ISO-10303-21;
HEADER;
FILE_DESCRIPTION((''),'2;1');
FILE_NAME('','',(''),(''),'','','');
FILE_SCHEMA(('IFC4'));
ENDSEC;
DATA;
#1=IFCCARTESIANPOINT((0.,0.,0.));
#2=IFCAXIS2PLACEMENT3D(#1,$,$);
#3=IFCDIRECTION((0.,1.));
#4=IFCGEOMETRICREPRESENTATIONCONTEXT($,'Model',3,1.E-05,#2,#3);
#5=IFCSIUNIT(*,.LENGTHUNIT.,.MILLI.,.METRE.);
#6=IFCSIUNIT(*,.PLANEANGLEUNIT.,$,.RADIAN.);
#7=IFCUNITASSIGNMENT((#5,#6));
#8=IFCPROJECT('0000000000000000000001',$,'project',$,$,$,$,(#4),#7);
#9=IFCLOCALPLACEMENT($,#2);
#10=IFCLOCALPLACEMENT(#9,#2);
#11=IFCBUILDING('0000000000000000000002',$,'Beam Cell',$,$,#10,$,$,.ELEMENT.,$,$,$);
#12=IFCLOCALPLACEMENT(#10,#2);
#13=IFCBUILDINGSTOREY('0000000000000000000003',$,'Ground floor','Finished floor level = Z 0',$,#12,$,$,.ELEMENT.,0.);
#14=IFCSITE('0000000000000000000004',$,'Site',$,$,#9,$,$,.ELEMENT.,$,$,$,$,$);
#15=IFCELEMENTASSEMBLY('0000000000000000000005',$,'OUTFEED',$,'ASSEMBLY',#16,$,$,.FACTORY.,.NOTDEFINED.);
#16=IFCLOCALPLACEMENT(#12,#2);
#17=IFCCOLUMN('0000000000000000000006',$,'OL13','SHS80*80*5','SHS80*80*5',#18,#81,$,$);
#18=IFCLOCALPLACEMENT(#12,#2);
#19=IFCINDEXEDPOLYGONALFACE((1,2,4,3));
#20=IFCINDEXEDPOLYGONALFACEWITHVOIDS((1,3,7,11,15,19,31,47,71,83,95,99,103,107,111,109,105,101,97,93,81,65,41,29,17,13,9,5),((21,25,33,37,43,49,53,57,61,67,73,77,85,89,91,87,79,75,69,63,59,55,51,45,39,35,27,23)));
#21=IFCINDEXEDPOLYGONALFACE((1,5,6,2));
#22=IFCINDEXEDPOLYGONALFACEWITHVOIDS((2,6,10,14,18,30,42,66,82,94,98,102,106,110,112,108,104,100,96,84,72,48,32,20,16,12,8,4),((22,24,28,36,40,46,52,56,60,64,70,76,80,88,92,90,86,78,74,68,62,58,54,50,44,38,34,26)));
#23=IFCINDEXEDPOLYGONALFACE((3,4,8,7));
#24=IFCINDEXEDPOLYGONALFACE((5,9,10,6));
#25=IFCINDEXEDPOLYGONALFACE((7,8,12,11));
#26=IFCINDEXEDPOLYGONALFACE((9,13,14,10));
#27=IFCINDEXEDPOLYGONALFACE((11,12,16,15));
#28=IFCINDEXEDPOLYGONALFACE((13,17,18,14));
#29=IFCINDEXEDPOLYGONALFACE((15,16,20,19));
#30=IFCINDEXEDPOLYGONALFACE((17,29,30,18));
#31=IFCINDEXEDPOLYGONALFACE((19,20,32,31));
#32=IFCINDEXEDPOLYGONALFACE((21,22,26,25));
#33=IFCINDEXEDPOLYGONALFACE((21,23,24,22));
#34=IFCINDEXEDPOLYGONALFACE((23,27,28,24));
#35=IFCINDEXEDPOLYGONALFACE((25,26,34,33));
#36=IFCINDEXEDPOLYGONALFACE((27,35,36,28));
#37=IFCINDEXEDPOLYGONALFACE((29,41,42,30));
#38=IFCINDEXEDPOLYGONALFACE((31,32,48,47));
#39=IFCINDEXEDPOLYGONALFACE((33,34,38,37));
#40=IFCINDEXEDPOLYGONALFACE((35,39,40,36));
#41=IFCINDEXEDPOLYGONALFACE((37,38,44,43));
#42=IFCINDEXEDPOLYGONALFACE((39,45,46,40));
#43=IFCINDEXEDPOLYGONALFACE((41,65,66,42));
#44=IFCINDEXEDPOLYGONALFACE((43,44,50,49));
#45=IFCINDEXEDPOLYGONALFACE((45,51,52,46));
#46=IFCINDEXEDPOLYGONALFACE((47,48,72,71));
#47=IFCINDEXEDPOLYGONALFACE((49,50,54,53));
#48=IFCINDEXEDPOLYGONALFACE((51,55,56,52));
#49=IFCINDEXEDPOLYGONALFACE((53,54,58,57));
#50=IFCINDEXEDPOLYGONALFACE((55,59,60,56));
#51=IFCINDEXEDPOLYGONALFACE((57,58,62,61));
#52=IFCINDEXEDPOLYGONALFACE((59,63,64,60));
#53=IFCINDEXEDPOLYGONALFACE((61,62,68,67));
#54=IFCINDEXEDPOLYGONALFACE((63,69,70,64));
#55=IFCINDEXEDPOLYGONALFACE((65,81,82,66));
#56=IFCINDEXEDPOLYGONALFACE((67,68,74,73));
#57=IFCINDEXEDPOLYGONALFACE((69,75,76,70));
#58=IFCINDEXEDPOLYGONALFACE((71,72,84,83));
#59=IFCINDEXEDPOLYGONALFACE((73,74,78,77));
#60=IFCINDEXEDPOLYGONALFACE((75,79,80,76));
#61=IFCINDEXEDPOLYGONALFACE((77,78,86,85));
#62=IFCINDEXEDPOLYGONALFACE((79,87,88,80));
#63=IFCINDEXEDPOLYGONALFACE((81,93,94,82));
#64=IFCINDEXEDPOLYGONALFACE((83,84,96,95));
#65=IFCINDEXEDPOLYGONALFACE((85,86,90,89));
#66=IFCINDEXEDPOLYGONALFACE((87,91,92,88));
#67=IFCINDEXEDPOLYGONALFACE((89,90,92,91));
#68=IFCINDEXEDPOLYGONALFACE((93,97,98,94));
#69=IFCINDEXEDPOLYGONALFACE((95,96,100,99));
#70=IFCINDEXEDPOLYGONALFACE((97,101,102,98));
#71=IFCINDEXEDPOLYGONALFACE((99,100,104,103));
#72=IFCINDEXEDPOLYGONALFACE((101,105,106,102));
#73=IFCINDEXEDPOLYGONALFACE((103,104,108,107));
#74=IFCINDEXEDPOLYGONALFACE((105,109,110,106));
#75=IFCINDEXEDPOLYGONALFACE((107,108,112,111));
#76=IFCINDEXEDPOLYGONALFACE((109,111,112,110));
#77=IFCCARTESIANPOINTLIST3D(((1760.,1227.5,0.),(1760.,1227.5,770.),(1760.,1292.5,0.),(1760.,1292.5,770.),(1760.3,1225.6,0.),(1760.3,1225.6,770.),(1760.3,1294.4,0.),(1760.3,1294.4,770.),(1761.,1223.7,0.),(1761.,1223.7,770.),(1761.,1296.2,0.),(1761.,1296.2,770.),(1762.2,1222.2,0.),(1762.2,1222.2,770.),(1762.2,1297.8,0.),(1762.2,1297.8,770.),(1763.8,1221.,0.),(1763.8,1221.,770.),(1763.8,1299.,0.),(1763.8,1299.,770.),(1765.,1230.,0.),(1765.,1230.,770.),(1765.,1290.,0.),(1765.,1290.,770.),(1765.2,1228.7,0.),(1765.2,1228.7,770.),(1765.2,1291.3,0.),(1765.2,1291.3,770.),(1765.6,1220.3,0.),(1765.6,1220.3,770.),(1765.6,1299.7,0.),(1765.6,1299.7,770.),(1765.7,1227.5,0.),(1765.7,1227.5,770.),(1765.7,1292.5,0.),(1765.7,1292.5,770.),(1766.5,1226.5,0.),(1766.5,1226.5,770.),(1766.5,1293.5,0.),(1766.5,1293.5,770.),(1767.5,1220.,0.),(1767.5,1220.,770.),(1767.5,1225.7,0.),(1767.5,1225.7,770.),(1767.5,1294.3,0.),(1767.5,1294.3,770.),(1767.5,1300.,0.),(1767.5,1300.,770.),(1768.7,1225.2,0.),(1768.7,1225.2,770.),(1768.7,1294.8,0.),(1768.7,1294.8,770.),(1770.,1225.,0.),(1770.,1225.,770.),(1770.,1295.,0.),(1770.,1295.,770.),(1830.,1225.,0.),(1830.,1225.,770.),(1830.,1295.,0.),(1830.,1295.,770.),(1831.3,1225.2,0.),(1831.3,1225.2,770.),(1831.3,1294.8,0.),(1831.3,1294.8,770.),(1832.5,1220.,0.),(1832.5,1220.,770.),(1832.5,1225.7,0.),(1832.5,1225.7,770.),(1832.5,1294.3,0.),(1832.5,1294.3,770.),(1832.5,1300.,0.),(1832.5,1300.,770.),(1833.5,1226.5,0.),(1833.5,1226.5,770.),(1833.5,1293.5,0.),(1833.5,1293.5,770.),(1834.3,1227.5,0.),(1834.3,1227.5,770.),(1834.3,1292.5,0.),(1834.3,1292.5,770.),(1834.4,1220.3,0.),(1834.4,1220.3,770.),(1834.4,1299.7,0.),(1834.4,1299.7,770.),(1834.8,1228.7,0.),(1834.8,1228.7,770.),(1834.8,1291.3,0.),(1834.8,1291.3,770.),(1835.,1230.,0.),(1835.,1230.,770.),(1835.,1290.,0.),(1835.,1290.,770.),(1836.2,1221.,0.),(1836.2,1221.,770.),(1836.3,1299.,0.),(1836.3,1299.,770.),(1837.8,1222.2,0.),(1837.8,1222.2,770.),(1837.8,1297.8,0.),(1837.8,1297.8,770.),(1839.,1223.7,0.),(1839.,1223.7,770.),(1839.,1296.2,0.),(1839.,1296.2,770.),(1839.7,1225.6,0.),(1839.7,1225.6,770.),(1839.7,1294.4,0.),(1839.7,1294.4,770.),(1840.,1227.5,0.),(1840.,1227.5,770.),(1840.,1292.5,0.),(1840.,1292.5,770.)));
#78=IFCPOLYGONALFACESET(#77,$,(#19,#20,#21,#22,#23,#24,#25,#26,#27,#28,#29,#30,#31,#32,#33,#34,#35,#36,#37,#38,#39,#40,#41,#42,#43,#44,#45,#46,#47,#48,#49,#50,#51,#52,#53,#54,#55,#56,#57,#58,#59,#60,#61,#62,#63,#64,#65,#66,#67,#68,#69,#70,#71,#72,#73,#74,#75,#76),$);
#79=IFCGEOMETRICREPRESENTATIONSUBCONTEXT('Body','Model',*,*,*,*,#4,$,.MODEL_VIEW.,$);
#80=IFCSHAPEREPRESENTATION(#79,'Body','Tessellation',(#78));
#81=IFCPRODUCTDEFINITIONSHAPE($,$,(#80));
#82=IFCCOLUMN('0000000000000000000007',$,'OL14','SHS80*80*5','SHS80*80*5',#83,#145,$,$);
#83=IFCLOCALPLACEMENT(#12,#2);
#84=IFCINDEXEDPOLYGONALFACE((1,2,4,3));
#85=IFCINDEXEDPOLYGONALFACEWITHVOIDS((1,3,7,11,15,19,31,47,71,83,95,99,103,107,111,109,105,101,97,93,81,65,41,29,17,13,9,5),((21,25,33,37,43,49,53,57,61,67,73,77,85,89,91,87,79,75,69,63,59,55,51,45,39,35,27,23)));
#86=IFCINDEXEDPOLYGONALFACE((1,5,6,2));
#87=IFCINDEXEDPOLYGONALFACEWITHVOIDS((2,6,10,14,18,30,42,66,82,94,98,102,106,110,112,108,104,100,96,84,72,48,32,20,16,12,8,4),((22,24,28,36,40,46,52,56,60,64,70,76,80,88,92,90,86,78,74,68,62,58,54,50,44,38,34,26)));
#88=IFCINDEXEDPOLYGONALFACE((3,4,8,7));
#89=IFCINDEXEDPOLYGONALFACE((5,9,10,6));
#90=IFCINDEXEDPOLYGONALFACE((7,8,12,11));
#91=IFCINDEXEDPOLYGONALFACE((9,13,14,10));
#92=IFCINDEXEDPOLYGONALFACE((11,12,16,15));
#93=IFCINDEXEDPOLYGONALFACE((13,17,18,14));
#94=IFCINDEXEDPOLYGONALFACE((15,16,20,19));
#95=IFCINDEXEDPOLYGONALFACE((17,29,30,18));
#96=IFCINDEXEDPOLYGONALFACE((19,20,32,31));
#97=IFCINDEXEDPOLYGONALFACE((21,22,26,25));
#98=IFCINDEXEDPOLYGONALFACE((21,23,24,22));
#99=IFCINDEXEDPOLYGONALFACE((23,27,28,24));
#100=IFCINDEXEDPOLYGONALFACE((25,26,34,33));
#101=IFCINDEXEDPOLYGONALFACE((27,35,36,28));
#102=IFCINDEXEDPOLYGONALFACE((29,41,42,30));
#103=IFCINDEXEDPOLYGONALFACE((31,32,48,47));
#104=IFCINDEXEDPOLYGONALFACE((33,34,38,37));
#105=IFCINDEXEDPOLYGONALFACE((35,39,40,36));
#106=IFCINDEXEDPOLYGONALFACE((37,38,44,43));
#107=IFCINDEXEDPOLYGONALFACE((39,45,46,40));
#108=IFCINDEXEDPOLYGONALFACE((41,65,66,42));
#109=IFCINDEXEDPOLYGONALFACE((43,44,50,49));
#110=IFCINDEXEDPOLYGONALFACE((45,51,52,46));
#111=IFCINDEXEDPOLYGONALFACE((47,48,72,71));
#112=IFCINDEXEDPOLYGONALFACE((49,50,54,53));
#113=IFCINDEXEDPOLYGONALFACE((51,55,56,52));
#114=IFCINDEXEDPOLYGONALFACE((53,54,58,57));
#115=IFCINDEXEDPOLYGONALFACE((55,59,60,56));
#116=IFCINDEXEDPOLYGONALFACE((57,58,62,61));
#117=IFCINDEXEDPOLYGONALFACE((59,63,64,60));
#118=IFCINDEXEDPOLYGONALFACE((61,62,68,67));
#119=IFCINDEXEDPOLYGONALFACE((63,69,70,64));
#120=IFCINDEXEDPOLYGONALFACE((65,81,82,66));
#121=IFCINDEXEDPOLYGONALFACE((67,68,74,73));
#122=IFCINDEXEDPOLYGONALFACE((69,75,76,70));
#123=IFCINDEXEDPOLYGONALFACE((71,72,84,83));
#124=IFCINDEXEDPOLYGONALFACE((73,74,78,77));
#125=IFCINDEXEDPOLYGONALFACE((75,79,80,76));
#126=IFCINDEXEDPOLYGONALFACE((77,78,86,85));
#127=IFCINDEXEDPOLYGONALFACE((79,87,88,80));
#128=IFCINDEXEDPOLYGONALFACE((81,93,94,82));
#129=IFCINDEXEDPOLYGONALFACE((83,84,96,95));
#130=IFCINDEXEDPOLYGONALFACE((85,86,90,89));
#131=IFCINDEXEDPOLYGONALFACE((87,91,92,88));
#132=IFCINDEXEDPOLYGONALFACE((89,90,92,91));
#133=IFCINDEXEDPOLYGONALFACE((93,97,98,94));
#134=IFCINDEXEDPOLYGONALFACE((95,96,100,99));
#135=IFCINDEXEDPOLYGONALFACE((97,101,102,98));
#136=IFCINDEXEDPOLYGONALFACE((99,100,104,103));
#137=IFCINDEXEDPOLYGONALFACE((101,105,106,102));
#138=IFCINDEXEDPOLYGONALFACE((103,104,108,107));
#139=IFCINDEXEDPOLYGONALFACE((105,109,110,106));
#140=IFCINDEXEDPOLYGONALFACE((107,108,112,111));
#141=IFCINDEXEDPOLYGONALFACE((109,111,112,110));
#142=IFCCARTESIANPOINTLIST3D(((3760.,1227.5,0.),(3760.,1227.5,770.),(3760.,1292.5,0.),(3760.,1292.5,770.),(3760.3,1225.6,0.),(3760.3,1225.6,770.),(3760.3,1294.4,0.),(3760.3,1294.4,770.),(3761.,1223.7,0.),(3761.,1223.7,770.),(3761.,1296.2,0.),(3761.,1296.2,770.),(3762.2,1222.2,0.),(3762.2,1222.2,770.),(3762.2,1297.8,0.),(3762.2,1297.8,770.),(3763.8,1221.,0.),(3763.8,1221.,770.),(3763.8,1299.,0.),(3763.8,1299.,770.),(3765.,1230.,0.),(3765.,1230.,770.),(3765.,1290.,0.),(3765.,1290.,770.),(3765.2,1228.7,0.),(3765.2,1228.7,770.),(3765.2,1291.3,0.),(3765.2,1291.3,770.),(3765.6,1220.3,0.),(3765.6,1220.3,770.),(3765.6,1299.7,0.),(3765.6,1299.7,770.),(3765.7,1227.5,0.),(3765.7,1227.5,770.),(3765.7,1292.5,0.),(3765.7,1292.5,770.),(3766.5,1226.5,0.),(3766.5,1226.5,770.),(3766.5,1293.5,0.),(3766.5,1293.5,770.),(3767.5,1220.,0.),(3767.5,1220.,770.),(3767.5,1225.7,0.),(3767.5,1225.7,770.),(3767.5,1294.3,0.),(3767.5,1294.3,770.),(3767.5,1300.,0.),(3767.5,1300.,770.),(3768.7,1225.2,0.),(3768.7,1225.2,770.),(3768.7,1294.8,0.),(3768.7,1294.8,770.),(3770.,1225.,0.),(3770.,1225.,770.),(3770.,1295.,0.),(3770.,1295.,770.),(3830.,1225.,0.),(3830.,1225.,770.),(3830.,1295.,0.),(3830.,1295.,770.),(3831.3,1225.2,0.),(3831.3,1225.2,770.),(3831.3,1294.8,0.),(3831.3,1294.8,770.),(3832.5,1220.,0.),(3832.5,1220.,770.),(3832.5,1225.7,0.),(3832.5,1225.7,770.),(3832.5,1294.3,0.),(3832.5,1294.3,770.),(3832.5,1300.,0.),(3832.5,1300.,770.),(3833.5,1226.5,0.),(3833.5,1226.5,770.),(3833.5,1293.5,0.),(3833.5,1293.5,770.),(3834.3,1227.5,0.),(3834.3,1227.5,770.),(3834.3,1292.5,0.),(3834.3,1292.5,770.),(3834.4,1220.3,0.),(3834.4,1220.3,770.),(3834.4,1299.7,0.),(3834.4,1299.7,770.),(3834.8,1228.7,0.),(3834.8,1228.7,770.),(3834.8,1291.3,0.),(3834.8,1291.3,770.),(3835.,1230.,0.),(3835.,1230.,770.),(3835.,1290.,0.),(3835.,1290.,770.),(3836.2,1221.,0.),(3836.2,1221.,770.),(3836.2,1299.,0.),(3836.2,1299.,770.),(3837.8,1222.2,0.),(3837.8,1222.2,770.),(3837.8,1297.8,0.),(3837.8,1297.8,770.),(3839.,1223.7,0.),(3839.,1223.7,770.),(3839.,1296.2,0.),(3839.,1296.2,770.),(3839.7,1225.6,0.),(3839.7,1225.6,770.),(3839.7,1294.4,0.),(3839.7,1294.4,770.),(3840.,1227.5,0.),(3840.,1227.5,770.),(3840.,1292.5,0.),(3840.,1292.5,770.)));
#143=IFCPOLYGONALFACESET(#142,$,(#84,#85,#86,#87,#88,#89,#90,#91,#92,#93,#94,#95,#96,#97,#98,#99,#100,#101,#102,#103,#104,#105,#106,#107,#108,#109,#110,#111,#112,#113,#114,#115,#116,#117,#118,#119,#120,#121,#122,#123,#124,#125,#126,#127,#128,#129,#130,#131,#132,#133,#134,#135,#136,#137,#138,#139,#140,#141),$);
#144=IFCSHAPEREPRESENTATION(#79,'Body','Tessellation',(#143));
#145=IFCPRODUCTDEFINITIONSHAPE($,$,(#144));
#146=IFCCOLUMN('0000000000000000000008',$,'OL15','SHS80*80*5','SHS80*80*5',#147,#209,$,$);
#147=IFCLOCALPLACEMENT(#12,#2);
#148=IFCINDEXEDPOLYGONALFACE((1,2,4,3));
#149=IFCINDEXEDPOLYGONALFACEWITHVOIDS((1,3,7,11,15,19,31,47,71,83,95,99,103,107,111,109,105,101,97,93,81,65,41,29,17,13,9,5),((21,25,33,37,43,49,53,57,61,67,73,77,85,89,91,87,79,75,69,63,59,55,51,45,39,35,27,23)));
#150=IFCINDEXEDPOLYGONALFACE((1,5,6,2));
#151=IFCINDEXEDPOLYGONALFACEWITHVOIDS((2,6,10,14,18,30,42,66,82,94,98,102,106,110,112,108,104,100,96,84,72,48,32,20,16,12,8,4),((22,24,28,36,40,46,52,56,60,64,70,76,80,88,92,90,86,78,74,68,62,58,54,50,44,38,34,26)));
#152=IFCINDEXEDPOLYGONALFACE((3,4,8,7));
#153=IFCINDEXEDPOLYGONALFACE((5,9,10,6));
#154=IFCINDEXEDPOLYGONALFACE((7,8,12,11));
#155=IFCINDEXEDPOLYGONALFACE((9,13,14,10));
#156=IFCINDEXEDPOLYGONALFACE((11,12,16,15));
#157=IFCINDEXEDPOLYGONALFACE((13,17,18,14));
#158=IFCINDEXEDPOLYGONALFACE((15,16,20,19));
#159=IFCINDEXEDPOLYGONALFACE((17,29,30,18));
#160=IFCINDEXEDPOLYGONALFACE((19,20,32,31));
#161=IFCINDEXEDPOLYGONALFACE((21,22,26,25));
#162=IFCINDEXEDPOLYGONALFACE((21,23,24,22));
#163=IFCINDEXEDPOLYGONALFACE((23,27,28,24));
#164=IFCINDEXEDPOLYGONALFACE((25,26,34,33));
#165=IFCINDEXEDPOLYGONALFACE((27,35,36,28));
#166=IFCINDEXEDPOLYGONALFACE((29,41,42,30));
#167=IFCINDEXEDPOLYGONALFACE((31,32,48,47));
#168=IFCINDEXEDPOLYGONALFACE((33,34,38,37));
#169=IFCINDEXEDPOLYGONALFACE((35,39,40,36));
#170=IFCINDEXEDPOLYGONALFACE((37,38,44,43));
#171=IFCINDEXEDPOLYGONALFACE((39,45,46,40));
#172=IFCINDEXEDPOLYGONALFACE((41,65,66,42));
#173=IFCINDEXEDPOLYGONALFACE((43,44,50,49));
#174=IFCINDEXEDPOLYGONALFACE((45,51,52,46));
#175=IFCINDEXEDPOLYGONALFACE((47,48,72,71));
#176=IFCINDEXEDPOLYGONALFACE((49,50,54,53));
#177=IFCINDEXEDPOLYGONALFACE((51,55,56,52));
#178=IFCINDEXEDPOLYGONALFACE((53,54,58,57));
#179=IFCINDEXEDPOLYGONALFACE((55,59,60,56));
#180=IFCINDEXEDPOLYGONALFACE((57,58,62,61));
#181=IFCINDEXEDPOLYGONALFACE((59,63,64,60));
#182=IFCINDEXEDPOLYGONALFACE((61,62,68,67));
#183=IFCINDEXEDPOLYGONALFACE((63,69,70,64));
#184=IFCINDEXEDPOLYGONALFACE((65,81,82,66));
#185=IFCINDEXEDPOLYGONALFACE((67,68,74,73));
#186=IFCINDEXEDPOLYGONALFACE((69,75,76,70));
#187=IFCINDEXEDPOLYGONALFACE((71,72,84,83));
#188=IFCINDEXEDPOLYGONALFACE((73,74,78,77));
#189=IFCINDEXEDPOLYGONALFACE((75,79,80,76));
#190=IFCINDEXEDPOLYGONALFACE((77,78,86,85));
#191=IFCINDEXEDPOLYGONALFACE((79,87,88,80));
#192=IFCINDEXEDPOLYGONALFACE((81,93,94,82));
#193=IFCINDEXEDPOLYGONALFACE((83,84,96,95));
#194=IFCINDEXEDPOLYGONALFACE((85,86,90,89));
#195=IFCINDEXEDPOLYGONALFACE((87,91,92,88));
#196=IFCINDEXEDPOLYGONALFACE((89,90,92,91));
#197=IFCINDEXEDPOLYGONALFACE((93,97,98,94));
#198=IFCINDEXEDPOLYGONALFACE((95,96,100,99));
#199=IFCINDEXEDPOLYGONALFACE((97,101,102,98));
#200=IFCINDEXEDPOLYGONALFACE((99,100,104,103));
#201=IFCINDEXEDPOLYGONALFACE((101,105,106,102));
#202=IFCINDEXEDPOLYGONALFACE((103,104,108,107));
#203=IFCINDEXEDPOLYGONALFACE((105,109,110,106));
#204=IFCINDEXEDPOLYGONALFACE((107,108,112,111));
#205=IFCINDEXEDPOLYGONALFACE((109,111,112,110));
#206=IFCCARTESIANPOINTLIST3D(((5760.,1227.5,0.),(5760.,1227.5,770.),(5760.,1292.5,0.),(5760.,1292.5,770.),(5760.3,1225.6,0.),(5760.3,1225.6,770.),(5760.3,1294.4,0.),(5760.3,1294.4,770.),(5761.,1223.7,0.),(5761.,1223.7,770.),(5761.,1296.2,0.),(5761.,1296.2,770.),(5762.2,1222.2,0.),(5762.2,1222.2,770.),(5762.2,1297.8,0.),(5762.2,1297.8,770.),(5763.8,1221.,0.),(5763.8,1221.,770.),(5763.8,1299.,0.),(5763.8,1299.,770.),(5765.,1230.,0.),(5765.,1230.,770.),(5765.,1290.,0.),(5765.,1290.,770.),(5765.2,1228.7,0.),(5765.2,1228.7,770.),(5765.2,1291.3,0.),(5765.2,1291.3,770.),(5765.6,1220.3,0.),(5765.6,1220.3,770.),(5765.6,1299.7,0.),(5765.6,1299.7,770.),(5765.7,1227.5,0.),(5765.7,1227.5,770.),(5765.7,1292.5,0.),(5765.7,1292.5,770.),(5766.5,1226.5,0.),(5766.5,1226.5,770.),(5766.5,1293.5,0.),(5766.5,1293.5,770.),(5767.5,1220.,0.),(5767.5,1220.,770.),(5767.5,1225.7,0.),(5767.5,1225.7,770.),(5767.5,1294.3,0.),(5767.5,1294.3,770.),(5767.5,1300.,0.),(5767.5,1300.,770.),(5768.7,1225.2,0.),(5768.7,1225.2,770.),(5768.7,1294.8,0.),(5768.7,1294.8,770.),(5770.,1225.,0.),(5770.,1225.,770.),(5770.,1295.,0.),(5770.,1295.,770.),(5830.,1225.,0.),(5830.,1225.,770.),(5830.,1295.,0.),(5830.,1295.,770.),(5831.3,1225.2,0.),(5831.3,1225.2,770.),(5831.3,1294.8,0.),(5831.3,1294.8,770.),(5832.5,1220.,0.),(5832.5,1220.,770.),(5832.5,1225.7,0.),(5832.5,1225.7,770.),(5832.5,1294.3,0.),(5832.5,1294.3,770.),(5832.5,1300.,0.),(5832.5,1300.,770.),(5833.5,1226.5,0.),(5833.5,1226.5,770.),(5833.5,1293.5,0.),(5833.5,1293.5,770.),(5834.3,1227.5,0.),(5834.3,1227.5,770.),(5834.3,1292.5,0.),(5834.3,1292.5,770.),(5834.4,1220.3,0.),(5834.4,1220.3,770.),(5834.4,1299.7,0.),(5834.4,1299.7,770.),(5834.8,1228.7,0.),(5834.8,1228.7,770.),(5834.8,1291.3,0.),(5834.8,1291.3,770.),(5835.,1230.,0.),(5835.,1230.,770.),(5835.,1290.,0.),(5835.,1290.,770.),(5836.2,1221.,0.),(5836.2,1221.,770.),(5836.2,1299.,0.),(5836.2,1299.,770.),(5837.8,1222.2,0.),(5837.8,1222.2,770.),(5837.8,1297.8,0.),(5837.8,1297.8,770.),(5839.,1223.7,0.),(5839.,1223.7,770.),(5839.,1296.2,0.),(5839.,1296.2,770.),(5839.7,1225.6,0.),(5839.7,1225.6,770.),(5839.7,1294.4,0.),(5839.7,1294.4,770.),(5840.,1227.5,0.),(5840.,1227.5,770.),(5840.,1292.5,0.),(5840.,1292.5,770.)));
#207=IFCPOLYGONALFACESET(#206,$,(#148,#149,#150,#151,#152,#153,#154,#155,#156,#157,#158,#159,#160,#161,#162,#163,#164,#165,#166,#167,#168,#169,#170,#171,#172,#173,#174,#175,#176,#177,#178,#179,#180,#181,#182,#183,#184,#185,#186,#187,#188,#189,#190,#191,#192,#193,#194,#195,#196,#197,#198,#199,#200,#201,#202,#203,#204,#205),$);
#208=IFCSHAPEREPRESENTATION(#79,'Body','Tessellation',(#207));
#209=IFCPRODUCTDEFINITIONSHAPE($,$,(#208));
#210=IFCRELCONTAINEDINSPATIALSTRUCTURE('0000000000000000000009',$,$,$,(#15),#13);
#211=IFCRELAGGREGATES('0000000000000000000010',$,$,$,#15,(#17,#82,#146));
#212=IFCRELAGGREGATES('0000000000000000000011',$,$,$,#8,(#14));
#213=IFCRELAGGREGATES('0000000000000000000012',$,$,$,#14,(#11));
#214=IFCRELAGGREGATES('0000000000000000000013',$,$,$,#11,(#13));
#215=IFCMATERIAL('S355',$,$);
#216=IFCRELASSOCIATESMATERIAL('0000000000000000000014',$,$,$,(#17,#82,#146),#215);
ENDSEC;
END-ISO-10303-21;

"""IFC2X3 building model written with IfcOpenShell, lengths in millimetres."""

from ifc_helpers import new_model, si_unit, direction, frame, origin, origin_2d, place, context, subcontext, project, spatial, hollow_rectangle, extrude, material, element, aggregate, save


model = new_model("IFC2X3")

# Units and contexts
model_context = context("Model", 3, precision=1e-05, world=origin(), true_north=direction((0.0, 1.0)))
body_context = subcontext(model_context, "Body", "Model", "MODEL_VIEW")
ifc_project = project(units=[si_unit("LENGTHUNIT", "METRE", prefix="MILLI"), si_unit("PLANEANGLEUNIT", "RADIAN")], contexts=[model_context])

# Site, building, storey
site_placement = place(None, origin())
site = spatial("IfcSite", under=ifc_project, at=site_placement, Name="Site", CompositionType="ELEMENT")
building_placement = place(site_placement, origin())
building = spatial("IfcBuilding", under=site, at=building_placement, Name="Beam Cell", CompositionType="ELEMENT")
storey_placement = place(building_placement, origin())
storey = spatial("IfcBuildingStorey", under=building, at=storey_placement, Name="Ground floor", Description="Finished floor level = Z 0", CompositionType="ELEMENT", Elevation=0.0)

# Element assembly, columns
ifc_material = material(Name="S355")
assembly_1_placement = place(storey_placement, origin())
assembly_1 = element("IfcElementAssembly", 1, at=assembly_1_placement, inside=storey, Name="OUTFEED", ObjectType="ASSEMBLY", AssemblyPlace="FACTORY", PredefinedType="NOTDEFINED")
column_1_placement = place(storey_placement, frame((1800.0, 1260.0, 0.0), z_axis=(0.0, 0.0, 1.0), x_axis=(1.0, 0.0, 0.0)))
column_1 = element("IfcColumn", 2, at=column_1_placement, material=ifc_material, Name="OL13", Description="SHS80*80*5", ObjectType="SHS80*80*5", context=body_context, shape_type="SweptSolid", body=[
    extrude(hollow_rectangle(XDim=80.0, YDim=80.0, WallThickness=5.0, InnerFilletRadius=5.0, OuterFilletRadius=7.5, at=origin_2d()), origin(), (0.0, 0.0, 1.0), 770.0),
])
column_2_placement = place(storey_placement, frame((3800.0, 1260.0, 0.0), z_axis=(0.0, 0.0, 1.0), x_axis=(1.0, 0.0, 0.0)))
column_2 = element("IfcColumn", 3, at=column_2_placement, material=ifc_material, Name="OL14", Description="SHS80*80*5", ObjectType="SHS80*80*5", context=body_context, shape_type="SweptSolid", body=[
    extrude(hollow_rectangle(XDim=80.0, YDim=80.0, WallThickness=5.0, InnerFilletRadius=5.0, OuterFilletRadius=7.5, at=origin_2d()), origin(), (0.0, 0.0, 1.0), 770.0),
])
column_3_placement = place(storey_placement, frame((5800.0, 1260.0, 0.0), z_axis=(0.0, 0.0, 1.0), x_axis=(1.0, 0.0, 0.0)))
column_3 = element("IfcColumn", 4, at=column_3_placement, material=ifc_material, Name="OL15", Description="SHS80*80*5", ObjectType="SHS80*80*5", context=body_context, shape_type="SweptSolid", body=[
    extrude(hollow_rectangle(XDim=80.0, YDim=80.0, WallThickness=5.0, InnerFilletRadius=5.0, OuterFilletRadius=7.5, at=origin_2d()), origin(), (0.0, 0.0, 1.0), 770.0),
])
aggregate(assembly_1, [column_1, column_2, column_3])

save(model, "model.ifc")
